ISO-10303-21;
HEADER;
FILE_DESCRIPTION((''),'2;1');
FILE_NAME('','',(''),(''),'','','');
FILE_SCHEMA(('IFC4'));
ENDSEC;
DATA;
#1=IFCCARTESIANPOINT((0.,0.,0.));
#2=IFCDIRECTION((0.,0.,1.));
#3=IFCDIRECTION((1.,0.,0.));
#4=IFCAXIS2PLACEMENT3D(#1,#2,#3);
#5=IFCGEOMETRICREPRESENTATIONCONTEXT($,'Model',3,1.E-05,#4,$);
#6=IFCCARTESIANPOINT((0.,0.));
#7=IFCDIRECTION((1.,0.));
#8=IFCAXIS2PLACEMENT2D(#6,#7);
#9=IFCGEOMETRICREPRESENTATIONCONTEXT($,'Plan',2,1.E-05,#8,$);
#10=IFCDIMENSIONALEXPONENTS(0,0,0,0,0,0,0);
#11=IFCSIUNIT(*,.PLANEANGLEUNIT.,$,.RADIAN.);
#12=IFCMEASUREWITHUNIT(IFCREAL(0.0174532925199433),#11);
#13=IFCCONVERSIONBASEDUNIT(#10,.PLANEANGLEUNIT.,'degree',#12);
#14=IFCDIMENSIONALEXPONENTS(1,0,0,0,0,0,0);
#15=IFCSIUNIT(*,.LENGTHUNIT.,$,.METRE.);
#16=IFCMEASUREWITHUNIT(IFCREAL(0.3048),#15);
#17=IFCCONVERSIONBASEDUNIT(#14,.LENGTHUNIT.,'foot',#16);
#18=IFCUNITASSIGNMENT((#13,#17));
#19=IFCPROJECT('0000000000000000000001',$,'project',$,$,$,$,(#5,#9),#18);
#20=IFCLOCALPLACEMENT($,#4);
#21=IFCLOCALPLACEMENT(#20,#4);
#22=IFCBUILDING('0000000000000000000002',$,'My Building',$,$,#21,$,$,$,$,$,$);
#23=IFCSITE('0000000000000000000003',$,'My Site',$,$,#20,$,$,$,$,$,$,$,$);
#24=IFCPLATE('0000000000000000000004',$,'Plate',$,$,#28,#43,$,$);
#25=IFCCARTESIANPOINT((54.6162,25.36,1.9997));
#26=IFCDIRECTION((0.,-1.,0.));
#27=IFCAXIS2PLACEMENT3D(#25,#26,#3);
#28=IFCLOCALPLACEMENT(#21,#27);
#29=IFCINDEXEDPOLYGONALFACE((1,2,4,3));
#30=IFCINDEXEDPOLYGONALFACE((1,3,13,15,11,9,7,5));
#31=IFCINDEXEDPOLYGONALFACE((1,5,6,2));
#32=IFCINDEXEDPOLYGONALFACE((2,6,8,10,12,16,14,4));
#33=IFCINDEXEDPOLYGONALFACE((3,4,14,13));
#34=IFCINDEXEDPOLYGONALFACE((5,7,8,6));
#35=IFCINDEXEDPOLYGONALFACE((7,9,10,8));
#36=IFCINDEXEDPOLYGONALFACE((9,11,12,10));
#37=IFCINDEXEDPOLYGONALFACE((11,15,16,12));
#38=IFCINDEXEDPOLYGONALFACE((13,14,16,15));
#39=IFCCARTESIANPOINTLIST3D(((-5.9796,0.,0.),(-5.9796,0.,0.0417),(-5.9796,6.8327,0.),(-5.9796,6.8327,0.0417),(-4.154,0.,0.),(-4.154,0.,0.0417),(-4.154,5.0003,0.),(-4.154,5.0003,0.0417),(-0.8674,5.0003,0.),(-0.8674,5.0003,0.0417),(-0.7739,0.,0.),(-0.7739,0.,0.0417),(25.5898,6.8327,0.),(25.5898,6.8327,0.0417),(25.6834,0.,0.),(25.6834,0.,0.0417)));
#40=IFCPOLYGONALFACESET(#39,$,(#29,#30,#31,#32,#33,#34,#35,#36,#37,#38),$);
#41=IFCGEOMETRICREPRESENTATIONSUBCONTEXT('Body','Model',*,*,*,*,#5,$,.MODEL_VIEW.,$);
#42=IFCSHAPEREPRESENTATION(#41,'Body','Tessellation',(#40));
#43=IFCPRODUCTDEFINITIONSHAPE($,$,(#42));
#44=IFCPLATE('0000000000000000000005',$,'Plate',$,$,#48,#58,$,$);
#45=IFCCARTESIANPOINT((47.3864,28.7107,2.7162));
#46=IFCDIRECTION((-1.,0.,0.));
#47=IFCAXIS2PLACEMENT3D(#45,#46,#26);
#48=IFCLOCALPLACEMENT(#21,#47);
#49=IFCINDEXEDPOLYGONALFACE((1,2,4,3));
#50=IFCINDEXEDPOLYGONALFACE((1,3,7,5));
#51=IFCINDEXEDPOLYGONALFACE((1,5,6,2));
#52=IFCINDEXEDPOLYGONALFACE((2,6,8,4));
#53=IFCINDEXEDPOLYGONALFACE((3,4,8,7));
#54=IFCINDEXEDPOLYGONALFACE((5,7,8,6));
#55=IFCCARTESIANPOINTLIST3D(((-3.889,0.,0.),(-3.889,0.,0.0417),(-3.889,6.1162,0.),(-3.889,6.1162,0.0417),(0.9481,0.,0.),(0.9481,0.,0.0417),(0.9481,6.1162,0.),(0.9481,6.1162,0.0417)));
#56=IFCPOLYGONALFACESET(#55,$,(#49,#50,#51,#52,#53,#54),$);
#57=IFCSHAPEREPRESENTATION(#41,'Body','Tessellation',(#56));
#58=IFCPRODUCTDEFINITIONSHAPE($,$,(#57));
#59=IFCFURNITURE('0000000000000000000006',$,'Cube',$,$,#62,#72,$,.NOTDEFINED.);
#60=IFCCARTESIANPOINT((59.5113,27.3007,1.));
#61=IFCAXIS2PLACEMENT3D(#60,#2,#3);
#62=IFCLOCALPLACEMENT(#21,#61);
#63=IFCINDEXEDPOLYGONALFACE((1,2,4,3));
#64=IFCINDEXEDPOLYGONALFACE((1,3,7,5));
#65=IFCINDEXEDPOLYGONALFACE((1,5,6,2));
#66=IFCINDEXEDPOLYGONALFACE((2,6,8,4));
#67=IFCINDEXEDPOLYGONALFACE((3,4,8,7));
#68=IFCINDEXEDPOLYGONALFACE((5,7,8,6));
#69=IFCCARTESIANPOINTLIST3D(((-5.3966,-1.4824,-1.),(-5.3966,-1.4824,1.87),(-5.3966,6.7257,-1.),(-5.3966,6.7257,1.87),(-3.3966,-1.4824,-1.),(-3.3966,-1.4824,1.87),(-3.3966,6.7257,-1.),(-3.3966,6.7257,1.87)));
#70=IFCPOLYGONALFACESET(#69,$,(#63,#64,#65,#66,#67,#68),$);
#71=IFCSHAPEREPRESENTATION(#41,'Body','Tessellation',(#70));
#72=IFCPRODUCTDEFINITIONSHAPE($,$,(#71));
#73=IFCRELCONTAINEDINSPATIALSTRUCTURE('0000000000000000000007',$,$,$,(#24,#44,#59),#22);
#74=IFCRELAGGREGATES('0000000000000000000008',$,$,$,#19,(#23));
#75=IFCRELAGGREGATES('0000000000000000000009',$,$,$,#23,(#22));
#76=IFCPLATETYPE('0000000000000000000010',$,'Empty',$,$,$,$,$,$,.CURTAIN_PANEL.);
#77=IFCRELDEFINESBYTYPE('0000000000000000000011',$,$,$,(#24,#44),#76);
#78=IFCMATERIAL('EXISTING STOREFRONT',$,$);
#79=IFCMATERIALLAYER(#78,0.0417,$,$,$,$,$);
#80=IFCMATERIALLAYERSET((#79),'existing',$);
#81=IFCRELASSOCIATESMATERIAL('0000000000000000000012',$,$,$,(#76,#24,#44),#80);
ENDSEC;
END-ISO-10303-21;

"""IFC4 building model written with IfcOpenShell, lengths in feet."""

from ifc_helpers import new_model, entity, si_unit, converted_unit, frame, origin_with_axes, origin_2d_with_axis, place, context, subcontext, project, spatial, line, indexed_curve, outline, extrude, material, layer, layer_set, layer_usage, type_object, element, save


model = new_model("IFC4")

# Units and contexts
model_context = context("Model", 3, precision=1e-05, world=origin_with_axes())
plan_context = context("Plan", 2, precision=1e-05, world=origin_2d_with_axis())
body_context_1 = subcontext(model_context, "Body", "Model", "MODEL_VIEW")
ifc_project = project(units=[converted_unit("PLANEANGLEUNIT", "degree", entity("IfcReal", 0.0174532925199433), si_unit("PLANEANGLEUNIT", "RADIAN"), dimensions=[0, 0, 0, 0, 0, 0, 0]), converted_unit("LENGTHUNIT", "foot", entity("IfcReal", 0.3048), si_unit("LENGTHUNIT", "METRE"), dimensions=[1, 0, 0, 0, 0, 0, 0])], contexts=[model_context, plan_context])

# Site, building
site_placement = place(None, origin_with_axes())
site = spatial("IfcSite", under=ifc_project, at=site_placement, Name="My Site")
building_placement = place(site_placement, origin_with_axes())
building = spatial("IfcBuilding", under=site, at=building_placement, Name="My Building")

# Plates
ifc_material_1 = material(Name="EXISTING STOREFRONT")
ifc_layer_1 = layer(ifc_material_1, 0.0417)
ifc_layer_set_1 = layer_set([ifc_layer_1], Name="existing")
ifc_layer_usage_1 = layer_usage(ifc_layer_set_1, "AXIS3", "POSITIVE", 0.0)
plate_type = type_object("IfcPlateType", Name="Empty", PredefinedType="CURTAIN_PANEL", material=ifc_layer_set_1)
plate_1_placement = place(building_placement, frame((54.6162, 25.36, 1.9997), z_axis=(0.0, -1.0, 0.0), x_axis=(1.0, 0.0, 0.0)))
element("IfcPlate", 1, at=plate_1_placement, inside=building, type_object=plate_type, material=ifc_layer_usage_1, Name="Plate", context=body_context_1, shape_type="SweptSolid", body=[
    extrude(outline(indexed_curve([(-0.8674, 5.0003), (-0.7739, 0.0), (25.6834, 0.0), (25.5898, 6.8327), (-5.9796, 6.8327), (-5.9796, 0.0), (-4.154, 0.0), (-4.154, 5.0003)], segments=[line(1, 8), line(8, 7), line(7, 6), line(6, 5), line(5, 4), line(4, 3), line(3, 2), line(2, 1)], self_intersect=False)), None, (0.0, 0.0, 1.0), 0.0417),
])
ifc_layer_usage_2 = layer_usage(ifc_layer_set_1, "AXIS3", "POSITIVE", 0.0)
plate_2_placement = place(building_placement, frame((47.3864, 28.7107, 2.7162), z_axis=(-1.0, 0.0, 0.0), x_axis=(0.0, -1.0, 0.0)))
element("IfcPlate", 2, at=plate_2_placement, inside=building, type_object=plate_type, material=ifc_layer_usage_2, Name="Plate", context=body_context_1, shape_type="SweptSolid", body=[
    extrude(outline(indexed_curve([(-3.889, 0.0), (-3.889, 6.1162), (0.9481, 6.1162), (0.9481, 0.0)], segments=[line(3, 2), line(2, 1), line(1, 4), line(4, 3)], self_intersect=False)), None, (0.0, 0.0, 1.0), 0.0417),
])

# Furniture
furniture_placement = place(building_placement, frame((59.5113, 27.3007, 1.0), z_axis=(0.0, 0.0, 1.0), x_axis=(1.0, 0.0, 0.0)))
element("IfcFurniture", 3, at=furniture_placement, inside=building, Name="Cube", PredefinedType="NOTDEFINED", context=body_context_1, shape_type="SweptSolid", body=[
    extrude(outline(indexed_curve([(-3.3966, -6.7257), (-5.3966, -6.7257), (-5.3966, 1.4824), (-3.3966, 1.4824)], segments=[line(4, 1), line(1, 2), line(2, 3), line(3, 4)], self_intersect=False)), frame((0.0, 0.0, -1.0), z_axis=(0.0, 0.0, -1.0), x_axis=(1.0, 0.0, 0.0)), (0.0, 0.0, -1.0), 2.87),
])

save(model, "model.ifc")
